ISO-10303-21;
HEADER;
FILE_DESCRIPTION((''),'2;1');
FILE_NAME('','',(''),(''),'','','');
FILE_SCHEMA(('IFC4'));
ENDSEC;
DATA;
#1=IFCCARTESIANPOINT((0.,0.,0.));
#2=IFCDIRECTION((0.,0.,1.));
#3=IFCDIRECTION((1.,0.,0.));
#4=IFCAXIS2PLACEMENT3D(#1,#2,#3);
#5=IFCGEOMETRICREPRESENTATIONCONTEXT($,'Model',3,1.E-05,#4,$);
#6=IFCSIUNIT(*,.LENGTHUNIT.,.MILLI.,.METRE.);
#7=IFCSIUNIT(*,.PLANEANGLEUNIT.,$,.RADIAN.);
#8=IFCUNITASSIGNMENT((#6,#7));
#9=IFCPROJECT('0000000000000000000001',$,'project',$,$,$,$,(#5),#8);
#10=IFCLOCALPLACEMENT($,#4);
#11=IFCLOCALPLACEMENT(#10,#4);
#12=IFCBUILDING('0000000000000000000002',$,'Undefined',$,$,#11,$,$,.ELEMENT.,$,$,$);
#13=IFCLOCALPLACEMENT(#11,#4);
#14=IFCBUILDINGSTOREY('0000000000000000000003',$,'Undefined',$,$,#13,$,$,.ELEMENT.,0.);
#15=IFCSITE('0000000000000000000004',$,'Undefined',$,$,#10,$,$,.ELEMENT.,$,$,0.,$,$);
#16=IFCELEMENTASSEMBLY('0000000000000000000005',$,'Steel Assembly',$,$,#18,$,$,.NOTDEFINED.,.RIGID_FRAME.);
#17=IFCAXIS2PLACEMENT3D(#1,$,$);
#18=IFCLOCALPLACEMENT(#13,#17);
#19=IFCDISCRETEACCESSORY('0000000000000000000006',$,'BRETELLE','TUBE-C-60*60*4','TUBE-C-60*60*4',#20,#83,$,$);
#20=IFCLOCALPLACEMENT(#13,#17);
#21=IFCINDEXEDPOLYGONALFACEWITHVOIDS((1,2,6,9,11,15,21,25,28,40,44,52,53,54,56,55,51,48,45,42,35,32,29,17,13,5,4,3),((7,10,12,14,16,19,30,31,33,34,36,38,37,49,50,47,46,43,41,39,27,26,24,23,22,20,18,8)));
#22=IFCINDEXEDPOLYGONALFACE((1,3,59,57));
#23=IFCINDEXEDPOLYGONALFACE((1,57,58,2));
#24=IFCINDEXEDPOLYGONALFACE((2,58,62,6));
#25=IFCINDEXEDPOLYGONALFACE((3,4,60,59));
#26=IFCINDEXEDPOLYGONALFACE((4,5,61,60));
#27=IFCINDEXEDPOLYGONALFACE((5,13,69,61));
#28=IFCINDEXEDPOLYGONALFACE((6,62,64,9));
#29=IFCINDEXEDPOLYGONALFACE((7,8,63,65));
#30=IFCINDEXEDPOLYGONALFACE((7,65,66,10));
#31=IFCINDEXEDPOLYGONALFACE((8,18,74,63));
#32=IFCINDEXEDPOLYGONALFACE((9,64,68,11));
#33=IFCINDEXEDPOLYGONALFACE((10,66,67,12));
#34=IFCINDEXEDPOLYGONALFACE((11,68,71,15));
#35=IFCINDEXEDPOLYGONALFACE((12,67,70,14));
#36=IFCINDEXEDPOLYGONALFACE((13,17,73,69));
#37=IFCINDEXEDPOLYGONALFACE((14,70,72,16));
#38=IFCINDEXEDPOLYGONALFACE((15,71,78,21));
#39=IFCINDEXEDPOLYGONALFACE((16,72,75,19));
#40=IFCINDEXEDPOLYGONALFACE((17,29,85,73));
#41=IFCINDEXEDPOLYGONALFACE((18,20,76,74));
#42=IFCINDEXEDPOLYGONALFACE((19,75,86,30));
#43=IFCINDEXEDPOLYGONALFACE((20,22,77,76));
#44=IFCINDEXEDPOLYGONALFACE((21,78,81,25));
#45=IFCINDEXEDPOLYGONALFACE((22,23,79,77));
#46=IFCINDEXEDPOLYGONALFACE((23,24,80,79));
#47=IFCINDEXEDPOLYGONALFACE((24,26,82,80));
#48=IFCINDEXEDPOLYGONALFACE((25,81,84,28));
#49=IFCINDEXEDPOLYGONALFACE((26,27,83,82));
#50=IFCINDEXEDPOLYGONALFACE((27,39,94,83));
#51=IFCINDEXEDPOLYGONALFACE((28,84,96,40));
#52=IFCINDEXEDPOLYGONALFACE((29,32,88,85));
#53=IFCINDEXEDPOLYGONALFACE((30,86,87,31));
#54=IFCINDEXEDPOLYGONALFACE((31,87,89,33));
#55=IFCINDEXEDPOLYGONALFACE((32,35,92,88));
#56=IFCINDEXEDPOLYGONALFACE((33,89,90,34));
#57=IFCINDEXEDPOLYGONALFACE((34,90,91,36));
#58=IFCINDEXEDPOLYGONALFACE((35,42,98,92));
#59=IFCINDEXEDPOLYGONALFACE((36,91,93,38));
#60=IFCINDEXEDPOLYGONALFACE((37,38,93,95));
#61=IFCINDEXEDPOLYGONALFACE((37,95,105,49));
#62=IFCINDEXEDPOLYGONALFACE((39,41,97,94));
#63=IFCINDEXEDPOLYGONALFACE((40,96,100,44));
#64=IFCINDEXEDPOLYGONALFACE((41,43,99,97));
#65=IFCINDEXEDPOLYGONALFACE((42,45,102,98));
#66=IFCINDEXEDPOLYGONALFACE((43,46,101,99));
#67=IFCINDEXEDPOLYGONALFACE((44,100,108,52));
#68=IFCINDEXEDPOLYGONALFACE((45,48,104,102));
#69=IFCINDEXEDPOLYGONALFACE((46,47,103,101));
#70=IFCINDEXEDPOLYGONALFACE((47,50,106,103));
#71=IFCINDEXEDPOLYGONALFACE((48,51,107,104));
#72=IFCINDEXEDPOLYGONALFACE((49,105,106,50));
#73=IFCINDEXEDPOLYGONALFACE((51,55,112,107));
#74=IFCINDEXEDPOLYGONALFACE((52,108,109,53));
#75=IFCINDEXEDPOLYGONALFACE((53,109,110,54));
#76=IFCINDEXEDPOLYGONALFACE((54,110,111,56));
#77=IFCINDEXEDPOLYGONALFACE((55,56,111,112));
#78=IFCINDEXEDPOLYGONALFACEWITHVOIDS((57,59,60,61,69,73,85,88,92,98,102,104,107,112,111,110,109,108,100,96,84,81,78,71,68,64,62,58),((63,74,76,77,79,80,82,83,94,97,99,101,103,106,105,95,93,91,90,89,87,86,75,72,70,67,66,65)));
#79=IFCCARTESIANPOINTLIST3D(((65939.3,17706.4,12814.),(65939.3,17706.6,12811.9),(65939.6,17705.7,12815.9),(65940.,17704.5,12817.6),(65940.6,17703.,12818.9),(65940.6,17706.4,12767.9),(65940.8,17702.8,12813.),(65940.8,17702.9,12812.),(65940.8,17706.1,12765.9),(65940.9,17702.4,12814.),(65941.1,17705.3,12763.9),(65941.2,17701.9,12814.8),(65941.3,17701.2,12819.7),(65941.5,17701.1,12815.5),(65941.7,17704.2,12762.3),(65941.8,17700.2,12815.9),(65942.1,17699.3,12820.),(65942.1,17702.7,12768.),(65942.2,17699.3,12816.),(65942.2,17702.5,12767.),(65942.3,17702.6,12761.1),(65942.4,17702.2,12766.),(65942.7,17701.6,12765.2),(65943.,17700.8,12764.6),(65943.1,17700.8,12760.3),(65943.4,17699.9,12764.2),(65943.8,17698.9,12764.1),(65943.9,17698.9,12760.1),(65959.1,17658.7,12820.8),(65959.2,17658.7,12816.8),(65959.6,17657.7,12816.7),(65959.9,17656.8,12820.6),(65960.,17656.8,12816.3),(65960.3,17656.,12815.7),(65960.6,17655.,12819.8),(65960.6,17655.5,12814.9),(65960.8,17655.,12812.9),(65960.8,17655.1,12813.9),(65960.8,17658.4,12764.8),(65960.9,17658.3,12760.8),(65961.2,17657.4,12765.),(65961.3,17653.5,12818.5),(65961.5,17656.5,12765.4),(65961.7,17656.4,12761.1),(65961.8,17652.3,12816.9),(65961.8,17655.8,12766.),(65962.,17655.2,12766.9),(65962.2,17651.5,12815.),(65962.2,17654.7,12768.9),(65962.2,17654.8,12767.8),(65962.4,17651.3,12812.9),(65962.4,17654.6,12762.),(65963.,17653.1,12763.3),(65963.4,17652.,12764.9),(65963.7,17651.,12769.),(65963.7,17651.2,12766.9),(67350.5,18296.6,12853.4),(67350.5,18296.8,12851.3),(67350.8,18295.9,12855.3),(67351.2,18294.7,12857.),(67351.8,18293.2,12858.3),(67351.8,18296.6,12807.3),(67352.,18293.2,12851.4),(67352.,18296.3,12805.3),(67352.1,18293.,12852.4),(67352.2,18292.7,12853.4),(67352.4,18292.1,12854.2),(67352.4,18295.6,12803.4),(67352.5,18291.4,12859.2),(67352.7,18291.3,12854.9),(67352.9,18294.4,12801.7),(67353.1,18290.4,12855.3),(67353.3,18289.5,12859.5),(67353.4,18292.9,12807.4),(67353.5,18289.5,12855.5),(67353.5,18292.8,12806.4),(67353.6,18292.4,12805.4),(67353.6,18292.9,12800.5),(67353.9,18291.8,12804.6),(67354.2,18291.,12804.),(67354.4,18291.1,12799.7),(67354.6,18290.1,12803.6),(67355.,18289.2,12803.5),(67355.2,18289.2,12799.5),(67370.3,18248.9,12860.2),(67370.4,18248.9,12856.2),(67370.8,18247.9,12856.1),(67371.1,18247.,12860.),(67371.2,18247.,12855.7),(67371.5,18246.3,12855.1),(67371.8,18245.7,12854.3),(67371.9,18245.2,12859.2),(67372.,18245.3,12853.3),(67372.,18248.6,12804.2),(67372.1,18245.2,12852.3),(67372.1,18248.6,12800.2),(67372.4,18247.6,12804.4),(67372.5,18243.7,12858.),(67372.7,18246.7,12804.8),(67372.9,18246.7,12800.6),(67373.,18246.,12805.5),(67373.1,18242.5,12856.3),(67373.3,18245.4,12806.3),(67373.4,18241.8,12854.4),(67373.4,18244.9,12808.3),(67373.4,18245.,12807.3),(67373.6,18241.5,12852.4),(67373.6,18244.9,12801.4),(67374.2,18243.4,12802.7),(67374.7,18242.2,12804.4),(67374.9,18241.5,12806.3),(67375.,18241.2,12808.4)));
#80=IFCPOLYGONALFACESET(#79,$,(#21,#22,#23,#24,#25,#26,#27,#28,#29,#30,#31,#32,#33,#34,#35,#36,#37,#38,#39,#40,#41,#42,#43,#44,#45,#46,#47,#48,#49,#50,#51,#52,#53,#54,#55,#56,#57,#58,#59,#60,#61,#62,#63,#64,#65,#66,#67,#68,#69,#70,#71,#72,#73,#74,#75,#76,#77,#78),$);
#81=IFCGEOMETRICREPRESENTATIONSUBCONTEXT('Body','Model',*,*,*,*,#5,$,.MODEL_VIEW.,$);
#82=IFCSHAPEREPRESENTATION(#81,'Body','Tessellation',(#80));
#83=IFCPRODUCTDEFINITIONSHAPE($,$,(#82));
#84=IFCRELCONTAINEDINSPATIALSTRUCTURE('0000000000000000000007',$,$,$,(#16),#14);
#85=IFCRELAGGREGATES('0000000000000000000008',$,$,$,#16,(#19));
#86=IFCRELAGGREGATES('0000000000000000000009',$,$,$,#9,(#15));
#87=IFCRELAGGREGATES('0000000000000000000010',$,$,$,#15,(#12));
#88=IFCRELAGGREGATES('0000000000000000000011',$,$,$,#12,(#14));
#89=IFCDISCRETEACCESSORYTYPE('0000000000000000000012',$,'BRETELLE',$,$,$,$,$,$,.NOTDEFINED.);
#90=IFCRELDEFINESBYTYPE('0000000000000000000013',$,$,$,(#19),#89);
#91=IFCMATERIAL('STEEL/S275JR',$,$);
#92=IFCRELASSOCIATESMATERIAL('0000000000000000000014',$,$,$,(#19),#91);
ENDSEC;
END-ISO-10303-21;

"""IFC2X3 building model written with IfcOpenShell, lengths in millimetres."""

from ifc_helpers import new_model, si_unit, frame, origin_with_axes, origin_2d_with_axis, place, context, subcontext, project, spatial, hollow_rectangle, extrude, material, type_object, element, aggregate, save


model = new_model("IFC2X3")

# Units and contexts
model_context = context("Model", 3, precision=1e-05, world=origin_with_axes())
body_context = subcontext(model_context, "Body", "Model", "MODEL_VIEW")
ifc_project = project(units=[si_unit("LENGTHUNIT", "METRE", prefix="MILLI"), si_unit("PLANEANGLEUNIT", "RADIAN")], contexts=[model_context])

# Site, building, storey
site_placement = place(None, origin_with_axes())
site = spatial("IfcSite", under=ifc_project, at=site_placement, Name="Undefined", CompositionType="ELEMENT", RefElevation=0.0)
building_placement = place(site_placement, origin_with_axes())
building = spatial("IfcBuilding", under=site, at=building_placement, Name="Undefined", CompositionType="ELEMENT")
storey_placement = place(building_placement, origin_with_axes())
storey = spatial("IfcBuildingStorey", under=building, at=storey_placement, Name="Undefined", CompositionType="ELEMENT", Elevation=0.0)

# Shared definitions
ifc_material = material(Name="STEEL/S275JR")

# Element assembly, discrete accessory
assembly_1_placement = place(storey_placement, origin_with_axes())
assembly_1 = element("IfcElementAssembly", 1, at=assembly_1_placement, inside=storey, Name="Steel Assembly", AssemblyPlace="NOTDEFINED", PredefinedType="RIGID_FRAME")
discrete_accessory_type_1 = type_object("IfcDiscreteAccessoryType", Name="BRETELLE")
discrete_accessory_1_placement = place(assembly_1_placement, frame((67362.7, 18269.0, 12829.9), z_axis=(-0.385384, 0.922596, -0.017211), x_axis=(-0.922255, -0.385722, -0.025763)))
discrete_accessory_1 = element("IfcDiscreteAccessory", 2, at=discrete_accessory_1_placement, type_object=discrete_accessory_type_1, material=ifc_material, Name="BRETELLE", Description="TUBE-C-60*60*4", ObjectType="TUBE-C-60*60*4", context=body_context, shape_type="SweptSolid", body=[
    extrude(hollow_rectangle(XDim=60.0, YDim=60.0, WallThickness=4.0, InnerFilletRadius=4.0, OuterFilletRadius=8.0, at=origin_2d_with_axis()), frame((1530.2, 0.0, 0.0), z_axis=(-1.0, 0.0, 0.0), x_axis=(0.0, -1.0, 0.0)), (0.0, 0.0, 1.0), 1530.2),
])
aggregate(assembly_1, [discrete_accessory_1])

save(model, "model.ifc")
